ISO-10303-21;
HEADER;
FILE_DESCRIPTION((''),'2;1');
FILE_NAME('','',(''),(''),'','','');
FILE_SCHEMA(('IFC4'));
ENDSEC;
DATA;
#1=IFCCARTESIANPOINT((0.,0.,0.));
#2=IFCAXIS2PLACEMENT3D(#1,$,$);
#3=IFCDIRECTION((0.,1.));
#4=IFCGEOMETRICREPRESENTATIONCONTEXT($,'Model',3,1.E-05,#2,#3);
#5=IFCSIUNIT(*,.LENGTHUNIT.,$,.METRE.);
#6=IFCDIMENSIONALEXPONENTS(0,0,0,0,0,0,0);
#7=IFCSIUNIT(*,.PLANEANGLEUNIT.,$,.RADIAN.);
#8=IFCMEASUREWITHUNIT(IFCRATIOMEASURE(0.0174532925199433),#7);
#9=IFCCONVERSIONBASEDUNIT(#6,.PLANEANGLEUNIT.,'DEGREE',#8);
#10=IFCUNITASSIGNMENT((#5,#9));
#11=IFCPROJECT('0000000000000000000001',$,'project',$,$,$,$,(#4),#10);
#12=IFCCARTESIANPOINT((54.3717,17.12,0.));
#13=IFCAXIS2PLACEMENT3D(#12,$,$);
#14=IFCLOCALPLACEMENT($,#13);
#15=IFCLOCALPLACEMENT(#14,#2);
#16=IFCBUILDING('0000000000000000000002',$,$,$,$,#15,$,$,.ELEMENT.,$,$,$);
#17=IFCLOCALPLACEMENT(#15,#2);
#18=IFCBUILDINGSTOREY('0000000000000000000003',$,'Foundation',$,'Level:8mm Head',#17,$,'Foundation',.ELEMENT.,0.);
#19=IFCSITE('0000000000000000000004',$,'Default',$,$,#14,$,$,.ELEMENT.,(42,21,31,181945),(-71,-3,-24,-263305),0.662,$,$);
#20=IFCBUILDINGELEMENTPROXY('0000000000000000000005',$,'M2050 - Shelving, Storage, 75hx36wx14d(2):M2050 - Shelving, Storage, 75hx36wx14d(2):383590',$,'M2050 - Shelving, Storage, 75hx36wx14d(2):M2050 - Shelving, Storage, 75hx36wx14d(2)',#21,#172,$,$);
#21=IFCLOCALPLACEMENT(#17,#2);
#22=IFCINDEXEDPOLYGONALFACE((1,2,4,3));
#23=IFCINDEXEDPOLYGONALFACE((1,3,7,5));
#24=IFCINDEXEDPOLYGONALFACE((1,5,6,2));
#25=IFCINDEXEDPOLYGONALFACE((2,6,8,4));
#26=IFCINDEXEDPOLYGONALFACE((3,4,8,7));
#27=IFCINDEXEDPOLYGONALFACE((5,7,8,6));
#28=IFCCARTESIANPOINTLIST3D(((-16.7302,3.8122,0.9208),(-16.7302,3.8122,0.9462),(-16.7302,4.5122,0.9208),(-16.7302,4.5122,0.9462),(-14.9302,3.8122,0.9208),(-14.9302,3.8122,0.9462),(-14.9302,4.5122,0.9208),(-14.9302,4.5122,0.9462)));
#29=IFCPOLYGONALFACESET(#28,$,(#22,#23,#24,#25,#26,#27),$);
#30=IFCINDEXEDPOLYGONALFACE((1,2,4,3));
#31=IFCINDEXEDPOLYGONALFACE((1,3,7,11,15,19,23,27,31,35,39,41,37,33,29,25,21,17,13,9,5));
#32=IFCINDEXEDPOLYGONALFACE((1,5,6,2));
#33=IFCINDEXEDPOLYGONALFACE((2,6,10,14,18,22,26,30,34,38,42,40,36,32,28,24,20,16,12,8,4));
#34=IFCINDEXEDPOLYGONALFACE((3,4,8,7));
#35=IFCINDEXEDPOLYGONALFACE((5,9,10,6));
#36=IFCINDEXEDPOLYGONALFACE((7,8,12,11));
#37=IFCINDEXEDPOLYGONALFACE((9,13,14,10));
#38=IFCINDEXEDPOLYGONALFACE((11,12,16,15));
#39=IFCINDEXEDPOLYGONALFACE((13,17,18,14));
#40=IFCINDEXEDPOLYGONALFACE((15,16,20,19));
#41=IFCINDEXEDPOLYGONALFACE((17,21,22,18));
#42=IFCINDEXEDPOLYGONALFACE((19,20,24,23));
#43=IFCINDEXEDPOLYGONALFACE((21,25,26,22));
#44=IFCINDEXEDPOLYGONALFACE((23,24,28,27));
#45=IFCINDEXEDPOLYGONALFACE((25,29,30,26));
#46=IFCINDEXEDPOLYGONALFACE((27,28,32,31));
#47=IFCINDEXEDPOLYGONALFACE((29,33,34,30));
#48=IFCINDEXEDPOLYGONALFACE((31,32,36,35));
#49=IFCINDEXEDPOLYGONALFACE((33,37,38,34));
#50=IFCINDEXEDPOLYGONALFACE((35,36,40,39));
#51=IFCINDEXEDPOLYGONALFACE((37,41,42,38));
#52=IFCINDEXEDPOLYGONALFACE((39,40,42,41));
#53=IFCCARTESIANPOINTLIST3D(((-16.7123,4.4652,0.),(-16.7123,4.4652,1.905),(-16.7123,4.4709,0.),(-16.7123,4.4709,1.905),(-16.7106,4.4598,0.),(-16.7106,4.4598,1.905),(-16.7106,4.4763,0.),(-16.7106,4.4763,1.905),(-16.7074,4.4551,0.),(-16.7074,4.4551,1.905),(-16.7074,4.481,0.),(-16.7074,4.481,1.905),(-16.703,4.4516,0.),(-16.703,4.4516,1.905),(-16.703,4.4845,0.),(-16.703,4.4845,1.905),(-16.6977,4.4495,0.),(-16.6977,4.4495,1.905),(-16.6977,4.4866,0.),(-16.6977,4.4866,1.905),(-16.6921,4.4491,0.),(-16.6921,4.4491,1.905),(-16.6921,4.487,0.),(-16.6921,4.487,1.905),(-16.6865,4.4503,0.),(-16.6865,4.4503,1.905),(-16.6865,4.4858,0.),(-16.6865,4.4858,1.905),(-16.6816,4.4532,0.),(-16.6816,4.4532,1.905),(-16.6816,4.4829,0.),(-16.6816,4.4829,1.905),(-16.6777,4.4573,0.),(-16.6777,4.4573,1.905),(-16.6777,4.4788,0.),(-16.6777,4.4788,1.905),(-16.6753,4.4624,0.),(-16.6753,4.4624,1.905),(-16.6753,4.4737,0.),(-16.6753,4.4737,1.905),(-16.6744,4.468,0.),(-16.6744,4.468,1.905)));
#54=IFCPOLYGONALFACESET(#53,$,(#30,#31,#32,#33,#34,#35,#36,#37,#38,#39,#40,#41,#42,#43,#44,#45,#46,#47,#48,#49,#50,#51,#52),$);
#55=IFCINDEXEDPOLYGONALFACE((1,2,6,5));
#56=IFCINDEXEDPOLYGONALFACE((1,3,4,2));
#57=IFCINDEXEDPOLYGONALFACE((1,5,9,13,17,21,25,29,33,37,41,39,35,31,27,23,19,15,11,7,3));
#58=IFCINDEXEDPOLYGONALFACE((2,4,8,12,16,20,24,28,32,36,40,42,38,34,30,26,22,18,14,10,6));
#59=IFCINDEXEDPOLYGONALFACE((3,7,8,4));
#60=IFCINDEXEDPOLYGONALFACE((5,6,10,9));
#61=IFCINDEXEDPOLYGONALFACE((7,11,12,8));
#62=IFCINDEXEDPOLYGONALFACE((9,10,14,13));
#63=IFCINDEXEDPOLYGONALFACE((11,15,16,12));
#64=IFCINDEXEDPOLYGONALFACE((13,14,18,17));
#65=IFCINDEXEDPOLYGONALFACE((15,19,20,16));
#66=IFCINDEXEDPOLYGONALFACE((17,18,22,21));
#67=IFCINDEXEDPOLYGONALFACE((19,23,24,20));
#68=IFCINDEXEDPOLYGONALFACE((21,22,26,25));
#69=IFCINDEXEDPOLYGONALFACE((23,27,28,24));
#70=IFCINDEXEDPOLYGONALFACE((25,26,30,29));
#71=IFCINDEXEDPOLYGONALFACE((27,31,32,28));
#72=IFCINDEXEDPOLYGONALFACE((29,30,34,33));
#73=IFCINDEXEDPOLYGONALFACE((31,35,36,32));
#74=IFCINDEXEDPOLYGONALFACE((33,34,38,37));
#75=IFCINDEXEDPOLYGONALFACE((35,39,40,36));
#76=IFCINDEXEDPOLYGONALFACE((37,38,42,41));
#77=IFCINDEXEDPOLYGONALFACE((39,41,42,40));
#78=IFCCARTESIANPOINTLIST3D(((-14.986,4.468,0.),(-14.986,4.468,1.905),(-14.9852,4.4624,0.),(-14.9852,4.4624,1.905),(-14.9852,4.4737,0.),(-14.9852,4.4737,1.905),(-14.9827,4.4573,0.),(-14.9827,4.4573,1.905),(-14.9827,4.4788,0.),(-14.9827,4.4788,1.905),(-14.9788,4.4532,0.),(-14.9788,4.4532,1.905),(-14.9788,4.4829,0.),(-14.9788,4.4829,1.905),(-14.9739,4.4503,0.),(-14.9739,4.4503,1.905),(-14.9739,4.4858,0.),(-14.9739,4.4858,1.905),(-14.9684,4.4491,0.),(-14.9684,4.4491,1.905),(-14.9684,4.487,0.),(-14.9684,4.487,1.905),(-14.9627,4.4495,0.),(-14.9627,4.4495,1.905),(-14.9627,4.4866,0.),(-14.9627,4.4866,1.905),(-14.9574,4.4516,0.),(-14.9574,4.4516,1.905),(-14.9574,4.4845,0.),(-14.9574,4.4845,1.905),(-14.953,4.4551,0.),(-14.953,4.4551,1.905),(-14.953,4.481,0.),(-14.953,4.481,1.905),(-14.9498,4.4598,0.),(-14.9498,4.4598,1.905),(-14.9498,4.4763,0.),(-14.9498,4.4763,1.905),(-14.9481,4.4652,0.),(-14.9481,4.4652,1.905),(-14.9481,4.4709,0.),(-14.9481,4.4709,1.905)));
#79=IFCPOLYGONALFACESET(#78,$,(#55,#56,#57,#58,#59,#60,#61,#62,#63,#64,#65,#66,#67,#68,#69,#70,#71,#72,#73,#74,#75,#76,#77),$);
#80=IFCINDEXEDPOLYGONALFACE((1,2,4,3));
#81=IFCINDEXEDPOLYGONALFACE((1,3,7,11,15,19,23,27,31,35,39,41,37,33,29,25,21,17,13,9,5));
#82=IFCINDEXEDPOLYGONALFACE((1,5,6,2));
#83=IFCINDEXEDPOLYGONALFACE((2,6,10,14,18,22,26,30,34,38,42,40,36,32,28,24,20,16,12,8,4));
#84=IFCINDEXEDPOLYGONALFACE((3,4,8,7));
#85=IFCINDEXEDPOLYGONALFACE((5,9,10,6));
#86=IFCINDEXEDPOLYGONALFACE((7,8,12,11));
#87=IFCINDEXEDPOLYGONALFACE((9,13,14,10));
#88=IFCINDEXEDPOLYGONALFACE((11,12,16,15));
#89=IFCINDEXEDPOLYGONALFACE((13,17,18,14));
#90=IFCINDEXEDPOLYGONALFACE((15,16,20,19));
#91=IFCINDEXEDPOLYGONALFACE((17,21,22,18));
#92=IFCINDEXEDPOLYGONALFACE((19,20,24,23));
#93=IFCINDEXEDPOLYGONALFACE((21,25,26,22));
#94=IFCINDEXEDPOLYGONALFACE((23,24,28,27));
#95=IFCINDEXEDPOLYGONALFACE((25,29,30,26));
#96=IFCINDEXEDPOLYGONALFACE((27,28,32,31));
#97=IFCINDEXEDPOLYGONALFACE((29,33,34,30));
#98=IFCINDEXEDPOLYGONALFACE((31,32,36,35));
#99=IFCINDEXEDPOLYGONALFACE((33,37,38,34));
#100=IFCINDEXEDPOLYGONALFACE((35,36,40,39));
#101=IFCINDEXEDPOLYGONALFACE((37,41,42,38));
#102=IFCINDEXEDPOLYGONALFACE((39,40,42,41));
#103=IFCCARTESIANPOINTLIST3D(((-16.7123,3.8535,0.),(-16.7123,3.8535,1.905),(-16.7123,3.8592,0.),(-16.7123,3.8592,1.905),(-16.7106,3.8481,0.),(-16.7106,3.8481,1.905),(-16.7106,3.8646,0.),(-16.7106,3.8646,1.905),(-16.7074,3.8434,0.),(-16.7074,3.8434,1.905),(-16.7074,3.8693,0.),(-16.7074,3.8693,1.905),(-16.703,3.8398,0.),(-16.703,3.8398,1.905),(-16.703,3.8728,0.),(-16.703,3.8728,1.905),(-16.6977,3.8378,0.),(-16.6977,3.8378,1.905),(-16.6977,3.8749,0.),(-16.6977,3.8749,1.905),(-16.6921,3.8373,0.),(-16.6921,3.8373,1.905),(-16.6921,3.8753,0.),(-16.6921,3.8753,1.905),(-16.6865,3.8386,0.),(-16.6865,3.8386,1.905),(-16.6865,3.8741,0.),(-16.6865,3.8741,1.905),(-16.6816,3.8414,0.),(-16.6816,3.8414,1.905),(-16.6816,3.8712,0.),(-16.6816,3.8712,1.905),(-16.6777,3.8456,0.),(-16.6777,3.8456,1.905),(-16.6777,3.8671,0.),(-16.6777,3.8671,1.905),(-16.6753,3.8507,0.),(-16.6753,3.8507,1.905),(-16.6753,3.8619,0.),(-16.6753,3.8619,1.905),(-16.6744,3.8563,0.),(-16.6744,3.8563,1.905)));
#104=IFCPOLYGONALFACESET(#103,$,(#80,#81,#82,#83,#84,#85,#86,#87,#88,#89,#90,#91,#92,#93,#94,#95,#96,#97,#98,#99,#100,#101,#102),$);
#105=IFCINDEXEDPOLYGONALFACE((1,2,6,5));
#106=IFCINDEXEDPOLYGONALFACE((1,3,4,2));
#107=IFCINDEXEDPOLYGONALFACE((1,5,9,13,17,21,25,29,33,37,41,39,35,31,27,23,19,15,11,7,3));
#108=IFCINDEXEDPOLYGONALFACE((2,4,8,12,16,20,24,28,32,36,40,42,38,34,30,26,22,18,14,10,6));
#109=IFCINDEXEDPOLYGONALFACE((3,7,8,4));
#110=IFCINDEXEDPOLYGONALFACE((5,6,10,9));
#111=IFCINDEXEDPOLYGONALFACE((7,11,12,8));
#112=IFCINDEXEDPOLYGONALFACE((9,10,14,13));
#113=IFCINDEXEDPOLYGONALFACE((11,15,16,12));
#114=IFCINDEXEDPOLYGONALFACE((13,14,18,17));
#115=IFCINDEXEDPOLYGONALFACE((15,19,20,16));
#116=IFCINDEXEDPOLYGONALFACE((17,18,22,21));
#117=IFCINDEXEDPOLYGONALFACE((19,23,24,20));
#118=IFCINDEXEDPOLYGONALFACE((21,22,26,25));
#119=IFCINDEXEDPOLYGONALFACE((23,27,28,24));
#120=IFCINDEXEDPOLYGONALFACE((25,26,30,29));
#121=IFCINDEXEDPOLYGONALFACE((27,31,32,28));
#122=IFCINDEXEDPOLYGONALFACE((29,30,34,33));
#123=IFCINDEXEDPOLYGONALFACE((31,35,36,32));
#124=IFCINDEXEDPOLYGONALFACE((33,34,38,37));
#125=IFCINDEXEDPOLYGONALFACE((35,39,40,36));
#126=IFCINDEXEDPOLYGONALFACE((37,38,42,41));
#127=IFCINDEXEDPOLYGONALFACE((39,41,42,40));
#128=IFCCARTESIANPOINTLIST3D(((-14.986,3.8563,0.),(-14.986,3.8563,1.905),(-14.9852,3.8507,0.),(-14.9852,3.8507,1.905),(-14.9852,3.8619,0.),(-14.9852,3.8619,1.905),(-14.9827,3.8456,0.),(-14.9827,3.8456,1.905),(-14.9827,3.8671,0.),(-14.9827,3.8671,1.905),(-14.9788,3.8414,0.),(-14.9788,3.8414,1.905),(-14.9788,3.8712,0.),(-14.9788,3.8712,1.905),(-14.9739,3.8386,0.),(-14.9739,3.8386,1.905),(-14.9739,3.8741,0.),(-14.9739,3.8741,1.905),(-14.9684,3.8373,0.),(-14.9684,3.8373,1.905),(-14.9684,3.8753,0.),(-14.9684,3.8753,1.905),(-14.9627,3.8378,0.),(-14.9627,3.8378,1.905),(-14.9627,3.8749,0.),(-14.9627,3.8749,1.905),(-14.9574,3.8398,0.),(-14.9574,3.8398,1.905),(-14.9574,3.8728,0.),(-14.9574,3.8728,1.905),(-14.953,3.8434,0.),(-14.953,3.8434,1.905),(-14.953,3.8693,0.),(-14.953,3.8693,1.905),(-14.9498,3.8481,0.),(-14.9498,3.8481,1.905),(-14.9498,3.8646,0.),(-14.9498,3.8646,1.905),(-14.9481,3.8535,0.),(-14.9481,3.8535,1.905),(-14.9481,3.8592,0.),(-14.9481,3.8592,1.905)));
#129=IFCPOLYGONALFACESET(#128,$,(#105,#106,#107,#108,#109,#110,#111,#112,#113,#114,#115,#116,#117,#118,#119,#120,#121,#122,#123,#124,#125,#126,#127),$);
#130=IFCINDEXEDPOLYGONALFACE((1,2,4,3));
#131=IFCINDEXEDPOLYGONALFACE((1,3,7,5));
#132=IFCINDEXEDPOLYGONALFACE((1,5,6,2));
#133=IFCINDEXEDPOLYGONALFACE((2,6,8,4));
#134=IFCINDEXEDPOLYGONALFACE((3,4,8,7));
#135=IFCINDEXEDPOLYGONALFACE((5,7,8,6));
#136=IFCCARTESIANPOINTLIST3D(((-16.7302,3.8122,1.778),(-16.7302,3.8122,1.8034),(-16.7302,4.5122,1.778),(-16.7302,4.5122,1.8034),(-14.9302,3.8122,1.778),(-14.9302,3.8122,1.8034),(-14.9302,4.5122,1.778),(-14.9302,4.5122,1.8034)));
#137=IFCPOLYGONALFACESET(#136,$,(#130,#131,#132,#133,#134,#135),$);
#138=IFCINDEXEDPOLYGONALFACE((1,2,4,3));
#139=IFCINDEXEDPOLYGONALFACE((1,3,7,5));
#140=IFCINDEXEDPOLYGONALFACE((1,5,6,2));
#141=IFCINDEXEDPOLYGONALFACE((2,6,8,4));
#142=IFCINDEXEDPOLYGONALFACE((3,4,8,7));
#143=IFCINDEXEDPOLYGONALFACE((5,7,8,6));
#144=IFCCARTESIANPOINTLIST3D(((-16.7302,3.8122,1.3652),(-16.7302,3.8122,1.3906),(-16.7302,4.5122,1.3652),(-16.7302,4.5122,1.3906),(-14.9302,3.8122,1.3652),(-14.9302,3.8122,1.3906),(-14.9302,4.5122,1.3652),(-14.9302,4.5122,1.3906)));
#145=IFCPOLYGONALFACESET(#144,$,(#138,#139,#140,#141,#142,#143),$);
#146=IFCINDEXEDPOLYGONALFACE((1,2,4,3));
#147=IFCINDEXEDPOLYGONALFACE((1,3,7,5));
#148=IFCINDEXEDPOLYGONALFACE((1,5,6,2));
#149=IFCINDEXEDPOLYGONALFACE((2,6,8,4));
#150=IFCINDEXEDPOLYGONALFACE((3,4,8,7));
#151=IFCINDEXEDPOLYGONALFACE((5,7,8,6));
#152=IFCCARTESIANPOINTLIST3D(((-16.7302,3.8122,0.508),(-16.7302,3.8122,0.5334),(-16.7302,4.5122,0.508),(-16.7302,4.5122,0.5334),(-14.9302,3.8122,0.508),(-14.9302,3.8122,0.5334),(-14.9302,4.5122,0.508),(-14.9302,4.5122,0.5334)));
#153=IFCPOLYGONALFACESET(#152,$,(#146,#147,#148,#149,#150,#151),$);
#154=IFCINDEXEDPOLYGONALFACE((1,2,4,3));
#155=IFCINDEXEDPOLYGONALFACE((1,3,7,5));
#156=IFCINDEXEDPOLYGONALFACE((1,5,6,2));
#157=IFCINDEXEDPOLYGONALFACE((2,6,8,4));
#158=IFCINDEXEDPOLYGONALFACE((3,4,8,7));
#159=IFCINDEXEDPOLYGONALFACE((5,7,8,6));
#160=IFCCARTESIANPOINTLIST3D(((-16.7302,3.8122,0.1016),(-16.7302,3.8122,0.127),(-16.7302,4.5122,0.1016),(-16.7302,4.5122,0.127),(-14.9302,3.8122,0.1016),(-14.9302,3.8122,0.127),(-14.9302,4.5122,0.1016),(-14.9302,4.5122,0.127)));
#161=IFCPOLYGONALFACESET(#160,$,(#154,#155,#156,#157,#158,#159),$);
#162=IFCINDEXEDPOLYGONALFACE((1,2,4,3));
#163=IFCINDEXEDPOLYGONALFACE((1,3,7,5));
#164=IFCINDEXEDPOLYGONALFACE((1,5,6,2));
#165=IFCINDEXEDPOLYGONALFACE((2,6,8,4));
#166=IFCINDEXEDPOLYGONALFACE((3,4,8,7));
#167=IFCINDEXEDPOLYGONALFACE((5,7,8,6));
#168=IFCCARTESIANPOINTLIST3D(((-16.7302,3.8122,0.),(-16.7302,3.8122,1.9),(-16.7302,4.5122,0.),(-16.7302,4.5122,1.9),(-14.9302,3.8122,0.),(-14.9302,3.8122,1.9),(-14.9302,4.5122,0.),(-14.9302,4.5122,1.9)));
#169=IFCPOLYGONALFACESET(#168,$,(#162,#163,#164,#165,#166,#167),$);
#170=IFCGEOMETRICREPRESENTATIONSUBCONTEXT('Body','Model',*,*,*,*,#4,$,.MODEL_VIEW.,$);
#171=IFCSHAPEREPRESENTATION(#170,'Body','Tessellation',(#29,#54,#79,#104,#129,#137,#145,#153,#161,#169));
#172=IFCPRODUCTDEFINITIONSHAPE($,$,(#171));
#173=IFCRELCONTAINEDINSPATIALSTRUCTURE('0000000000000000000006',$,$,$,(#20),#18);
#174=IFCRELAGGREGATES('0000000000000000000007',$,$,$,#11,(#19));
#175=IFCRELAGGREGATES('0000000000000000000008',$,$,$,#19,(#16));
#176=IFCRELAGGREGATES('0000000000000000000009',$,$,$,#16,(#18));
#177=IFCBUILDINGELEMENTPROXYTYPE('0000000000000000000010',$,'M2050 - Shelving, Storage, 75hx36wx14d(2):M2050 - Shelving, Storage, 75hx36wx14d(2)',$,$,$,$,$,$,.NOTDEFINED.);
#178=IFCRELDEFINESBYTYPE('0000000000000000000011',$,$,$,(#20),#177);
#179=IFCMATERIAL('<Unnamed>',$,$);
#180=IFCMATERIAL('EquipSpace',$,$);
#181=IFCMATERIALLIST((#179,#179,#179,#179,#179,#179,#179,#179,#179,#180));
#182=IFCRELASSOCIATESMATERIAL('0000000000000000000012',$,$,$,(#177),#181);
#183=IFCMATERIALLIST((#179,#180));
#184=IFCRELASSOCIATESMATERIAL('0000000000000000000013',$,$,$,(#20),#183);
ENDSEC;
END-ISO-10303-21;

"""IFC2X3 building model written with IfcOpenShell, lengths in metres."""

from ifc_helpers import new_model, entity, si_unit, converted_unit, direction, frame, frame_2d, origin, origin_2d_with_axis, place, context, subcontext, project, spatial, rectangle, circle, extrude, source, transform, mapped, material, material_list, type_object, type_shapes, element, save


model = new_model("IFC2X3")

# Units and contexts
model_context = context("Model", 3, precision=1e-05, world=origin(), true_north=direction((0.0, 1.0)))
body_context = subcontext(model_context, "Body", "Model", "MODEL_VIEW")
ifc_project = project(units=[si_unit("LENGTHUNIT", "METRE"), converted_unit("PLANEANGLEUNIT", "DEGREE", entity("IfcRatioMeasure", 0.0174532925199433), si_unit("PLANEANGLEUNIT", "RADIAN"), dimensions=[0, 0, 0, 0, 0, 0, 0])], contexts=[model_context])

# Site, building, storey
site_placement = place(None, frame((54.3717, 17.12, 0.0)))
site = spatial("IfcSite", under=ifc_project, at=site_placement, Name="Default", CompositionType="ELEMENT", RefLatitude=(42, 21, 31, 181945), RefLongitude=(-71, -3, -24, -263305), RefElevation=0.662)
building_placement = place(site_placement, origin())
building = spatial("IfcBuilding", under=site, at=building_placement, CompositionType="ELEMENT")
storey_placement = place(building_placement, origin())
storey = spatial("IfcBuildingStorey", under=building, at=storey_placement, Name="Foundation", ObjectType="Level:8mm Head", LongName="Foundation", CompositionType="ELEMENT", Elevation=0.0)

# Building element proxy
ifc_material_1 = material(Name="<Unnamed>")
ifc_material_2 = material(Name="EquipSpace")
ifc_material_list_1 = material_list([ifc_material_1, ifc_material_2])
ifc_material_list_2 = material_list([ifc_material_1, ifc_material_1, ifc_material_1, ifc_material_1, ifc_material_1, ifc_material_1, ifc_material_1, ifc_material_1, ifc_material_1, ifc_material_2])
building_element_proxy_type = type_object("IfcBuildingElementProxyType", Name="M2050 - Shelving, Storage, 75hx36wx14d(2):M2050 - Shelving, Storage, 75hx36wx14d(2)", PredefinedType="NOTDEFINED", material=ifc_material_list_2)
shared_shape = source(origin(), body_context, "Body", "SweptSolid", [
    extrude(rectangle(XDim=1.8, YDim=0.7, at=origin_2d_with_axis()), frame((0.0, 0.0, 0.9207), z_axis=(0.0, 0.0, 1.0), x_axis=(-1.0, 0.0, 0.0)), (0.0, 0.0, 1.0), 0.0254),
    extrude(circle(Radius=0.0191, at=origin_2d_with_axis()), frame((0.8633, -0.3059, 0.0), z_axis=(0.0, 0.0, 1.0), x_axis=(-1.0, 0.0, 0.0)), (0.0, 0.0, 1.0), 1.905),
    extrude(circle(Radius=0.0191, at=origin_2d_with_axis()), frame((-0.8633, -0.3059, 0.0)), (0.0, 0.0, 1.0), 1.905),
    extrude(circle(Radius=0.0191, at=origin_2d_with_axis()), frame((0.8633, 0.3059, 0.0), z_axis=(0.0, 0.0, 1.0), x_axis=(-1.0, 0.0, 0.0)), (0.0, 0.0, 1.0), 1.905),
    extrude(circle(Radius=0.0191, at=origin_2d_with_axis()), frame((-0.8633, 0.3059, 0.0)), (0.0, 0.0, 1.0), 1.905),
    extrude(rectangle(XDim=1.8, YDim=0.7, at=origin_2d_with_axis()), frame((0.0, 0.0, 1.778), z_axis=(0.0, 0.0, 1.0), x_axis=(-1.0, 0.0, 0.0)), (0.0, 0.0, 1.0), 0.0254),
    extrude(rectangle(XDim=1.8, YDim=0.7, at=origin_2d_with_axis()), frame((0.0, 0.0, 1.3653), z_axis=(0.0, 0.0, 1.0), x_axis=(-1.0, 0.0, 0.0)), (0.0, 0.0, 1.0), 0.0254),
    extrude(rectangle(XDim=1.8, YDim=0.7, at=origin_2d_with_axis()), frame((0.0, 0.0, 0.508), z_axis=(0.0, 0.0, 1.0), x_axis=(-1.0, 0.0, 0.0)), (0.0, 0.0, 1.0), 0.0254),
    extrude(rectangle(XDim=1.8, YDim=0.7, at=origin_2d_with_axis()), frame((0.0, 0.0, 0.1016), z_axis=(0.0, 0.0, 1.0), x_axis=(-1.0, 0.0, 0.0)), (0.0, 0.0, 1.0), 0.0254),
    extrude(rectangle(XDim=0.7, YDim=1.8, at=frame_2d((0.0, 0.18), x_axis=(1.0, 0.0))), frame((-0.18, 0.0, 0.0), z_axis=(0.0, 0.0, 1.0), x_axis=(0.0, -1.0, 0.0)), (0.0, 0.0, 1.0), 1.9),
])
type_shapes(building_element_proxy_type, [shared_shape])
proxy_1_placement = place(storey_placement, frame((-15.8302, 4.1622, 0.0), z_axis=(0.0, 0.0, 1.0), x_axis=(-1.0, 0.0, 0.0)))
element("IfcBuildingElementProxy", 1, at=proxy_1_placement, inside=storey, type_object=building_element_proxy_type, material=ifc_material_list_1, Name="M2050 - Shelving, Storage, 75hx36wx14d(2):M2050 - Shelving, Storage, 75hx36wx14d(2):383590", ObjectType="M2050 - Shelving, Storage, 75hx36wx14d(2):M2050 - Shelving, Storage, 75hx36wx14d(2)", context=body_context, shape_type="MappedRepresentation", body=[
    mapped(shared_shape, transform((0.0, 0.0, 0.0), scale=1.0)),
])

save(model, "model.ifc")
